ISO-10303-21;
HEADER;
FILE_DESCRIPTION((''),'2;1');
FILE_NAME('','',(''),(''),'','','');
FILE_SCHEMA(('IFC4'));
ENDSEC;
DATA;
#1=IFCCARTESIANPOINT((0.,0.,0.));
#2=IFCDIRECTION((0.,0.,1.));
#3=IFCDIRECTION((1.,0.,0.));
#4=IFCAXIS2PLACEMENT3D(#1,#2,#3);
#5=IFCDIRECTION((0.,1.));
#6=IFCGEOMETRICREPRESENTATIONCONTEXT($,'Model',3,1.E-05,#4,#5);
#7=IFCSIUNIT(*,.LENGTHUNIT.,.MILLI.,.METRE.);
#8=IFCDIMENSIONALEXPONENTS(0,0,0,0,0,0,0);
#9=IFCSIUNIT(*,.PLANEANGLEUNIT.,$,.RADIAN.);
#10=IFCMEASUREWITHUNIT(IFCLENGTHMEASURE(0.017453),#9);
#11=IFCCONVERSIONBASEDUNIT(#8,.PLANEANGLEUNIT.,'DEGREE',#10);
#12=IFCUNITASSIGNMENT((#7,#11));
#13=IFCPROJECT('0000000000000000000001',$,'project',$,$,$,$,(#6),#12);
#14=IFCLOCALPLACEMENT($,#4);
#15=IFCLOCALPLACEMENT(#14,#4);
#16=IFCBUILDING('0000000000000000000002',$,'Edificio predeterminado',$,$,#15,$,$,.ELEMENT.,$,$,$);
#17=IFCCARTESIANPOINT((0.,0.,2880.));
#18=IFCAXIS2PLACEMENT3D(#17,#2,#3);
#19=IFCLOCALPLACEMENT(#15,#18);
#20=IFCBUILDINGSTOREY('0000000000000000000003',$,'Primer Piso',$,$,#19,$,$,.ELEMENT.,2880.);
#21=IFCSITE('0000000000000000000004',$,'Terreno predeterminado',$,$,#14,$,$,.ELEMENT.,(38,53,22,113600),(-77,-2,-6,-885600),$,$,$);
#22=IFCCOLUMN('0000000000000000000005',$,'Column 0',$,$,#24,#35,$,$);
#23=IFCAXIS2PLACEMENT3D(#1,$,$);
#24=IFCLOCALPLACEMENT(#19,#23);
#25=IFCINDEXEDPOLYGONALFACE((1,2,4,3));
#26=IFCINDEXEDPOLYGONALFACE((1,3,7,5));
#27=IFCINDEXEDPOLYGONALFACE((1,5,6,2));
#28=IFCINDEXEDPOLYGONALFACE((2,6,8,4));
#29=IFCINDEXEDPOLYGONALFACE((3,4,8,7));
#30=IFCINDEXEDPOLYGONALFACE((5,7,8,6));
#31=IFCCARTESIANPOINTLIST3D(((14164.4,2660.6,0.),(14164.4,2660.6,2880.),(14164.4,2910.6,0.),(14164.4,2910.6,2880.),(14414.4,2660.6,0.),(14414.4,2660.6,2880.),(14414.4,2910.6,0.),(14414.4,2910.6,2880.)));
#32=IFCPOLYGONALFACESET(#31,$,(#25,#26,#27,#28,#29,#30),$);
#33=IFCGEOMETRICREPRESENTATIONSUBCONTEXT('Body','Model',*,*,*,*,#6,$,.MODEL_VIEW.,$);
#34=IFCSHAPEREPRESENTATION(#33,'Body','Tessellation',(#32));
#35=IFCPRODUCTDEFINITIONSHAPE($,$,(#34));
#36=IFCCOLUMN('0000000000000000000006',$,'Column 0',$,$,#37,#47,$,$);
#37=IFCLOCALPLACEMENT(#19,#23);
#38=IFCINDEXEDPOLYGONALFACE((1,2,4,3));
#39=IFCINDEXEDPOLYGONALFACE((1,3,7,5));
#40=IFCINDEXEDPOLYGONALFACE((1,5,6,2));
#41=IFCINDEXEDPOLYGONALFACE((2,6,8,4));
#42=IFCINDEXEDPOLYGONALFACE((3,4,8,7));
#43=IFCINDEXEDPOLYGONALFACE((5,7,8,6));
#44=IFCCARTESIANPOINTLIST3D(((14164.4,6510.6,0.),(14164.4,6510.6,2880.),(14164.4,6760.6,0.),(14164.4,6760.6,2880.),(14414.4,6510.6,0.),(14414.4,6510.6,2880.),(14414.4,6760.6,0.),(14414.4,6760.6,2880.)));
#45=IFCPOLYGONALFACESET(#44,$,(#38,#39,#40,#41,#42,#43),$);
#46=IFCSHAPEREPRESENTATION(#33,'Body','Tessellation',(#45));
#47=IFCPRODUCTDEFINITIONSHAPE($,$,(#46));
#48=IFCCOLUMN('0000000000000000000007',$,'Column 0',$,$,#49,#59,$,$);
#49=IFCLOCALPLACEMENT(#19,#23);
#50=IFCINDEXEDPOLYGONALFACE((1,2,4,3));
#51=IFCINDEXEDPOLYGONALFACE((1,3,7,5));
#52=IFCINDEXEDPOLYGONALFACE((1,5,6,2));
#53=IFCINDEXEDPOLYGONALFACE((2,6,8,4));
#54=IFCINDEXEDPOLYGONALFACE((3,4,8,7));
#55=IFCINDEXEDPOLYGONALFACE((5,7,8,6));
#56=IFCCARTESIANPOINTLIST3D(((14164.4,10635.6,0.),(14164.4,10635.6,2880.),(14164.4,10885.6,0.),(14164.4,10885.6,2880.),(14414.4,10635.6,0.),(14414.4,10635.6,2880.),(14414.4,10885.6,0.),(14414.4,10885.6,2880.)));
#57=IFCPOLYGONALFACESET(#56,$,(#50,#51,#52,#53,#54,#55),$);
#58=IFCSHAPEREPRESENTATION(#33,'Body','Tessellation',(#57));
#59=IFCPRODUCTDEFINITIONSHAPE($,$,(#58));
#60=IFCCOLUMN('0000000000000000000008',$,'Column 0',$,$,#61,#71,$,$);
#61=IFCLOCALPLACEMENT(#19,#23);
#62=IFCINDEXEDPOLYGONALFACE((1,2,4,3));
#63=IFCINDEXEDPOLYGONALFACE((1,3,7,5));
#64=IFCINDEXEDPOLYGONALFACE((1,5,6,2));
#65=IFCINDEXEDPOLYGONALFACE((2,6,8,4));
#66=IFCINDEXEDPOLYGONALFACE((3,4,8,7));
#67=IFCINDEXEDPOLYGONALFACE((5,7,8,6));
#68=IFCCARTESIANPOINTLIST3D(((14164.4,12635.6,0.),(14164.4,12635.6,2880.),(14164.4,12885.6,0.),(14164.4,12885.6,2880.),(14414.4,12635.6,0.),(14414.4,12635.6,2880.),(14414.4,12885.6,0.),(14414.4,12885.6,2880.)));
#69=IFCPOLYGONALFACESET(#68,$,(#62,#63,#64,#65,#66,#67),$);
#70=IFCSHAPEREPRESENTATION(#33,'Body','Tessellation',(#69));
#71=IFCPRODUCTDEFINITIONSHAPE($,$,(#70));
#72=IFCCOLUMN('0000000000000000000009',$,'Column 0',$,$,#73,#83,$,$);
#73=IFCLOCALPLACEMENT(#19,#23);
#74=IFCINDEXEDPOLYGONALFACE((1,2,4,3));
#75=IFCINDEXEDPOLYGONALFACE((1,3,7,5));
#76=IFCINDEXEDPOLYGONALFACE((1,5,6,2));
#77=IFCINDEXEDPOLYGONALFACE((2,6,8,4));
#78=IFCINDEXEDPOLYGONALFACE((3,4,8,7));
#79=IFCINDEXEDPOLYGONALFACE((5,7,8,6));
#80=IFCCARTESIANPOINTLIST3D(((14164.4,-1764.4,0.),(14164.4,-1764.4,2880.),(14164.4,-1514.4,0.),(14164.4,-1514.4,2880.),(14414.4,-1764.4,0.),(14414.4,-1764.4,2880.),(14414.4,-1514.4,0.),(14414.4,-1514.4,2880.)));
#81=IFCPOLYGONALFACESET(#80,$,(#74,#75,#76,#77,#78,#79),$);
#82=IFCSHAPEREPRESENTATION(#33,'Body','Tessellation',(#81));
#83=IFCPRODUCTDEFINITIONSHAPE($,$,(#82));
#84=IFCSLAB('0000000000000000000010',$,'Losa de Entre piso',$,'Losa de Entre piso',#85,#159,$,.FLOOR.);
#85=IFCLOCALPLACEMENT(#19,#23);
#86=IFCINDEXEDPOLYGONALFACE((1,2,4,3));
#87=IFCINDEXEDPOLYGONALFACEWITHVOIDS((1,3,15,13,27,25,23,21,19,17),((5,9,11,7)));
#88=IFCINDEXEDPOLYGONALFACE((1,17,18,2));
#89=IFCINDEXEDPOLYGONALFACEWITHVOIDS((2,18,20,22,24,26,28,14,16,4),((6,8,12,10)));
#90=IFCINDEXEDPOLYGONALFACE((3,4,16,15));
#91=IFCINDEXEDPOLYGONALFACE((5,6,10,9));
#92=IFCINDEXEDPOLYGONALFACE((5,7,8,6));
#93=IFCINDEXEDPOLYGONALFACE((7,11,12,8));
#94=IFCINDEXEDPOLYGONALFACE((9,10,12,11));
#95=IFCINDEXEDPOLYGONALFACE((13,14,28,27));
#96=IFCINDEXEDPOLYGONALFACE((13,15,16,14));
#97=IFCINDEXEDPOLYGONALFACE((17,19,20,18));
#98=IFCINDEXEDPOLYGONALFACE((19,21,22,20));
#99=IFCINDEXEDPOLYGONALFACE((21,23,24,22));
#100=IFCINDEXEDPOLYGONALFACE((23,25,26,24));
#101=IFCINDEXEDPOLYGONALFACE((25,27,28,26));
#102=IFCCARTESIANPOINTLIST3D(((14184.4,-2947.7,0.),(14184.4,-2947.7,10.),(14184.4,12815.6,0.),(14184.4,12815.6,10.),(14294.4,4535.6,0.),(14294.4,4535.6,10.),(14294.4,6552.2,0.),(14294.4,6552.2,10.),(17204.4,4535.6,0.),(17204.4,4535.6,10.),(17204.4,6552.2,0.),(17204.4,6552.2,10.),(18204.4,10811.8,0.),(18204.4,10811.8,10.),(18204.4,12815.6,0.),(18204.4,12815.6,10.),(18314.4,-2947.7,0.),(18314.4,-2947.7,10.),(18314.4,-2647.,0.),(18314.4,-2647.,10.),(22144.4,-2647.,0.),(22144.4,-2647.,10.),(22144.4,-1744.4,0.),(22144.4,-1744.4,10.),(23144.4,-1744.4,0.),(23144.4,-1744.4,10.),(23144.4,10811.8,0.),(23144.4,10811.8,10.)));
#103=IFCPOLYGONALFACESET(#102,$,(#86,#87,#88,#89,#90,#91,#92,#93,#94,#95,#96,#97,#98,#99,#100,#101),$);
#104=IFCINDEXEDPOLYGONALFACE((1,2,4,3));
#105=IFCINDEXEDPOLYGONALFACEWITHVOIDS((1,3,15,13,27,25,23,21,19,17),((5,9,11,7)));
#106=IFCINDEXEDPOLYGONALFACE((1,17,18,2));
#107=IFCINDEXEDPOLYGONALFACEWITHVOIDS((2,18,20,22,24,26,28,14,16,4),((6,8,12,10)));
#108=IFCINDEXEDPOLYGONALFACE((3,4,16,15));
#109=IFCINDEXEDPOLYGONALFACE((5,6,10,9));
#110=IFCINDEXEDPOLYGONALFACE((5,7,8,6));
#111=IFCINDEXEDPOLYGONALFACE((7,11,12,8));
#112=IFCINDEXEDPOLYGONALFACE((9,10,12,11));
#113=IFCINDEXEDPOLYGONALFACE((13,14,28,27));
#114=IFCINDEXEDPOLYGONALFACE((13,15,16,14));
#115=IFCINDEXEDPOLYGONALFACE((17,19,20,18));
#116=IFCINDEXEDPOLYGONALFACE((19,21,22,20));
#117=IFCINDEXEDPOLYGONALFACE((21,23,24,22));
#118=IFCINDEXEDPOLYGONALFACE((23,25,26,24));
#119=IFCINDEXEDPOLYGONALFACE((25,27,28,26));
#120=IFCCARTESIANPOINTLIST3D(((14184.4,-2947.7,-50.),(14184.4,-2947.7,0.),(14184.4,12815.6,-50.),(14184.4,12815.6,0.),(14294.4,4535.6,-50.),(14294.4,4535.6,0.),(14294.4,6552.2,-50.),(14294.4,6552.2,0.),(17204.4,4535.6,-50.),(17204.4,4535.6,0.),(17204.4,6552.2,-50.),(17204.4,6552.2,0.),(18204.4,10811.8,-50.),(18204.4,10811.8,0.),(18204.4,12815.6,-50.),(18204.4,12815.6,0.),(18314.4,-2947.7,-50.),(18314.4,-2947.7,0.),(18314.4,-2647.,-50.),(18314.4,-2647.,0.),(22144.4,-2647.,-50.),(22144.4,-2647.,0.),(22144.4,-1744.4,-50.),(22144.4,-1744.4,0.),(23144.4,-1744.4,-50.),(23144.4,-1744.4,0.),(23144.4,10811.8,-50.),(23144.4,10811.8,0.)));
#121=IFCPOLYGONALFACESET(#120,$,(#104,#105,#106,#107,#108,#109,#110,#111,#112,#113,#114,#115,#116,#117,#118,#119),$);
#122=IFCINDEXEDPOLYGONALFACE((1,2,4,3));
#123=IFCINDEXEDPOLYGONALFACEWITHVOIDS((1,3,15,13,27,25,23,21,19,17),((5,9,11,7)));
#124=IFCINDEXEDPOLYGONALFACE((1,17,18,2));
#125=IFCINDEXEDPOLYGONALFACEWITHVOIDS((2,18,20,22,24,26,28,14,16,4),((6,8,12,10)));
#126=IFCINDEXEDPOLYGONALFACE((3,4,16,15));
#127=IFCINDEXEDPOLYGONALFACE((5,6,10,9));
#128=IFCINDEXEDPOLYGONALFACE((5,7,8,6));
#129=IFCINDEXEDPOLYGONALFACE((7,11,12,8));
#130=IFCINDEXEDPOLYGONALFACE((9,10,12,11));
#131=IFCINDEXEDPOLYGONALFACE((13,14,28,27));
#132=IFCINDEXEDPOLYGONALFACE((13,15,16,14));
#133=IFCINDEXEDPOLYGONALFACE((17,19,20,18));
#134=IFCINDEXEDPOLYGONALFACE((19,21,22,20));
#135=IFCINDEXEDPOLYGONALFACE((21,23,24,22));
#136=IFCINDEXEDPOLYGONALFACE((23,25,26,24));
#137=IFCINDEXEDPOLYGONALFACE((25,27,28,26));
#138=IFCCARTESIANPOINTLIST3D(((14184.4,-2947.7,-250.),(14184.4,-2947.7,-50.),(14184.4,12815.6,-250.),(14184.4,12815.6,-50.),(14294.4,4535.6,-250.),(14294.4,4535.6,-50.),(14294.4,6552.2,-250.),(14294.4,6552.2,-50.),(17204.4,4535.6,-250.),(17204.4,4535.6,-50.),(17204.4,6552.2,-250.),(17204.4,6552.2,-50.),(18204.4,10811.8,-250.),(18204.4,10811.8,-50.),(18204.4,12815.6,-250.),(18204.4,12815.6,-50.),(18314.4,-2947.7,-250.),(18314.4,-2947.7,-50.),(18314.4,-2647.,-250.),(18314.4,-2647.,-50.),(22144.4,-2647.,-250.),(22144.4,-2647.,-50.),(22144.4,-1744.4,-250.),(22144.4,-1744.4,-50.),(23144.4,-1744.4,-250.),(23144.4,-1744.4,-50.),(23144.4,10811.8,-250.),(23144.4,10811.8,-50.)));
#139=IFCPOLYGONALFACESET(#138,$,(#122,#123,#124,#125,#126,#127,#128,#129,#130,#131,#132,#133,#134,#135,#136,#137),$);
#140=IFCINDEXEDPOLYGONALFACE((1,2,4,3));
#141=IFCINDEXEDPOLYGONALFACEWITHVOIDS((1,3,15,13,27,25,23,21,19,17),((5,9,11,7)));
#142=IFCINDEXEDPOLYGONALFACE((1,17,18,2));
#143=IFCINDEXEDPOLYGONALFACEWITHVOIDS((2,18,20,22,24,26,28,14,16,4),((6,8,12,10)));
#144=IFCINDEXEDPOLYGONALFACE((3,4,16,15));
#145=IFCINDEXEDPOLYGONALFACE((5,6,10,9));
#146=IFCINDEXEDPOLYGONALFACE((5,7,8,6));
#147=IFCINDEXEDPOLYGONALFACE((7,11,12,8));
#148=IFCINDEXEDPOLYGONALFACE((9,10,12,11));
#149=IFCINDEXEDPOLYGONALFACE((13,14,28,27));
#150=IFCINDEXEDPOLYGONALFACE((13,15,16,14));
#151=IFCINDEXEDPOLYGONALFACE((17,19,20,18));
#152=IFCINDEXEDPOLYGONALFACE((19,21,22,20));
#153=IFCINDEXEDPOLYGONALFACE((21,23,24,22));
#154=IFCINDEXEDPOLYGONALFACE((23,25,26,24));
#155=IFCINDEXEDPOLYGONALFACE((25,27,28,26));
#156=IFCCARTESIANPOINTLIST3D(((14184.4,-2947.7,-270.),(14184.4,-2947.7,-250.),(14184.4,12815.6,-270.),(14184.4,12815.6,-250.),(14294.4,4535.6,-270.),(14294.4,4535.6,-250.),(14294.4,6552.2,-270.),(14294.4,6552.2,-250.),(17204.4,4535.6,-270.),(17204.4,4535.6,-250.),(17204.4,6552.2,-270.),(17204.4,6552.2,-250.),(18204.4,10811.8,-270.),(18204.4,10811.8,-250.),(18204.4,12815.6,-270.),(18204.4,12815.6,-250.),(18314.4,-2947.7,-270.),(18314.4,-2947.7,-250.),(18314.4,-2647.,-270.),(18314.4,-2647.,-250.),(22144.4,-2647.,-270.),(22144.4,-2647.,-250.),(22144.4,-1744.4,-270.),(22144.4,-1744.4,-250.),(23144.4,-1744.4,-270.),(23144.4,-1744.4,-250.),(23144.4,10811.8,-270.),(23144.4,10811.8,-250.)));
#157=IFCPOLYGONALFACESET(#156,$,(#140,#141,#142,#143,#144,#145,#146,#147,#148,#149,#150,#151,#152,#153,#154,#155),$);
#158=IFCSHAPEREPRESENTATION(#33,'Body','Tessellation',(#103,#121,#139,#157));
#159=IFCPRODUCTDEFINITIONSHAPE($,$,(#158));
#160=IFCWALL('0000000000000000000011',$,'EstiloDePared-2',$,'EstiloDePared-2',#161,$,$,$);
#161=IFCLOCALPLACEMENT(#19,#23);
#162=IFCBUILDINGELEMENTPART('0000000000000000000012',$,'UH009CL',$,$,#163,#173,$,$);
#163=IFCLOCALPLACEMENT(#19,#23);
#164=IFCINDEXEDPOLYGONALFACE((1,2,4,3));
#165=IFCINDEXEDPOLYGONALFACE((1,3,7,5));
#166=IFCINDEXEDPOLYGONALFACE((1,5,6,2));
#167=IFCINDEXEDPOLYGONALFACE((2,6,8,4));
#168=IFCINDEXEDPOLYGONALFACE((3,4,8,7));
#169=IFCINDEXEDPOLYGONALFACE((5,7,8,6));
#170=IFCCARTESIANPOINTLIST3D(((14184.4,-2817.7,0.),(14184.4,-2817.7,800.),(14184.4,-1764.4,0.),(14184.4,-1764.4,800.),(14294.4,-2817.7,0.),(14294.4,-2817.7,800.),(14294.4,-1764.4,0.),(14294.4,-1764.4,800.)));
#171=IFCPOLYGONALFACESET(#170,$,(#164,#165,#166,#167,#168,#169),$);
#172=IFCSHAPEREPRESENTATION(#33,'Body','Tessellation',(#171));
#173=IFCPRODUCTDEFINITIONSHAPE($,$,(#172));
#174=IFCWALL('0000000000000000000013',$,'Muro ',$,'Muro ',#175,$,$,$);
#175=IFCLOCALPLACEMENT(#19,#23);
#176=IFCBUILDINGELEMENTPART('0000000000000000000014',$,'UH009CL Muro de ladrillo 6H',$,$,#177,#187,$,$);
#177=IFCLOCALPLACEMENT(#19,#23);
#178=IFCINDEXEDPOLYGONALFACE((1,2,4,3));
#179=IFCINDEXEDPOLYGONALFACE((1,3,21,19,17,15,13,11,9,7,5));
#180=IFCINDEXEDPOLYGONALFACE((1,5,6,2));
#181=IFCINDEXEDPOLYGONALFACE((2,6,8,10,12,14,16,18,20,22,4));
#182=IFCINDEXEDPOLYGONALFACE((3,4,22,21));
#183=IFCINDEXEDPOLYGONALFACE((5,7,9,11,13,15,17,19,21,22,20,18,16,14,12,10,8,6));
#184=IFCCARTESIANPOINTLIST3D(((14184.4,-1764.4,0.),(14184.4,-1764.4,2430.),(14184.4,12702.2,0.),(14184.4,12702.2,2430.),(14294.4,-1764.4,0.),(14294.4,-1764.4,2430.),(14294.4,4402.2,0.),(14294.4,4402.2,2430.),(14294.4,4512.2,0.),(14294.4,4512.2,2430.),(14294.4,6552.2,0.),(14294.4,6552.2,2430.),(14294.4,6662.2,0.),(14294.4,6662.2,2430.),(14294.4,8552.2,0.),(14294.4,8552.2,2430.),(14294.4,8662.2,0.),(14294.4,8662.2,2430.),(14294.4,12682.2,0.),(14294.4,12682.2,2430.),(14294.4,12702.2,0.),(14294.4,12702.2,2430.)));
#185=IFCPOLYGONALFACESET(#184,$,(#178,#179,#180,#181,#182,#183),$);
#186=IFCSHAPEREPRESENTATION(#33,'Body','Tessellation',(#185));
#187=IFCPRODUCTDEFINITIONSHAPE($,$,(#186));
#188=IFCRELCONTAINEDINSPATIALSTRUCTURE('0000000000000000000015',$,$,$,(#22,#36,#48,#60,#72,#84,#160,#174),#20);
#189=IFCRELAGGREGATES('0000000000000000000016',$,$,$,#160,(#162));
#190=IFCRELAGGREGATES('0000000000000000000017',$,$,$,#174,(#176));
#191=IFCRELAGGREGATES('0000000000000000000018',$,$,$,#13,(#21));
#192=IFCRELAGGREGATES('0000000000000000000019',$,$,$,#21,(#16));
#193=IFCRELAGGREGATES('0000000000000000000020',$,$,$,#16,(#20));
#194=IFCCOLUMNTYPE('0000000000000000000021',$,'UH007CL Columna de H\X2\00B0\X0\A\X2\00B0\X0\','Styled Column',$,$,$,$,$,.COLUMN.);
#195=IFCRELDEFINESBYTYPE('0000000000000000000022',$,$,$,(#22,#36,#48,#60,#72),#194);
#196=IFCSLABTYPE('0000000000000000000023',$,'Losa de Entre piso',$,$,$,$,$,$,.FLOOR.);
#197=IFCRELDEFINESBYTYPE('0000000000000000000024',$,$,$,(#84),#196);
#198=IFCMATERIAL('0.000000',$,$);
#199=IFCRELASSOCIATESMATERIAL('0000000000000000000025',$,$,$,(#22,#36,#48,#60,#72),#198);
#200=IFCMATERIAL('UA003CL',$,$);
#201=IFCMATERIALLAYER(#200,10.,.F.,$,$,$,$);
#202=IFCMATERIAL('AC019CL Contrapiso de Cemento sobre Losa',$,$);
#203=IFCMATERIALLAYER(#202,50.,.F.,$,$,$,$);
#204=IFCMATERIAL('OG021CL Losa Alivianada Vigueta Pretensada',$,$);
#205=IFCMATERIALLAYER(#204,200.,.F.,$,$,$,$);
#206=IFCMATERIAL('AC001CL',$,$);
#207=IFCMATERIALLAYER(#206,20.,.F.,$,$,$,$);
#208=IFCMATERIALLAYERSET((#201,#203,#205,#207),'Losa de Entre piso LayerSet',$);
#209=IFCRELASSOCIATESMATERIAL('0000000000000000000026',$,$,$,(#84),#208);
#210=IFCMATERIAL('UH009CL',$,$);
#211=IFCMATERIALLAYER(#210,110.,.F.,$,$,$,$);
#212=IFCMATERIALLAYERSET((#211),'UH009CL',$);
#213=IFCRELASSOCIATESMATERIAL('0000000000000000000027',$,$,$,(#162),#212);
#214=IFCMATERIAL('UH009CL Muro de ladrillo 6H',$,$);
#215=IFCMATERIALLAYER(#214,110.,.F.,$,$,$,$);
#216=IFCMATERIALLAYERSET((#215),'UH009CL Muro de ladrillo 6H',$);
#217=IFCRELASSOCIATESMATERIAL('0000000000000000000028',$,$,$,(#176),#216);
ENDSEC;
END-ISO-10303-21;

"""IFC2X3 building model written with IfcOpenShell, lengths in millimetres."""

from ifc_helpers import new_model, entity, si_unit, converted_unit, direction, frame, origin_with_axes, place, context, subcontext, project, spatial, polyline, outline, extrude, material, layer, layer_set, layer_usage, type_object, element, aggregate, save


model = new_model("IFC2X3")

# Units and contexts
model_context = context("Model", 3, precision=1e-05, world=origin_with_axes(), true_north=direction((0.0, 1.0)))
body_context = subcontext(model_context, "Body", "Model", "MODEL_VIEW")
ifc_project = project(units=[si_unit("LENGTHUNIT", "METRE", prefix="MILLI"), converted_unit("PLANEANGLEUNIT", "DEGREE", entity("IfcLengthMeasure", 0.017453), si_unit("PLANEANGLEUNIT", "RADIAN"), dimensions=[0, 0, 0, 0, 0, 0, 0])], contexts=[model_context])

# Site, building, storey
site_placement = place(None, origin_with_axes())
site = spatial("IfcSite", under=ifc_project, at=site_placement, Name="Terreno predeterminado", CompositionType="ELEMENT", RefLatitude=(38, 53, 22, 113600), RefLongitude=(-77, -2, -6, -885600))
building_placement = place(site_placement, origin_with_axes())
building = spatial("IfcBuilding", under=site, at=building_placement, Name="Edificio predeterminado", CompositionType="ELEMENT")
storey_placement = place(building_placement, frame((0.0, 0.0, 2880.0), z_axis=(0.0, 0.0, 1.0), x_axis=(1.0, 0.0, 0.0)))
storey = spatial("IfcBuildingStorey", under=building, at=storey_placement, Name="Primer Piso", CompositionType="ELEMENT", Elevation=2880.0)

# Columns
ifc_material_1 = material(Name="0.000000")
column_type = type_object("IfcColumnType", Name="UH007CL Columna de H°A°", Description="Styled Column", PredefinedType="COLUMN")
for number, where, z_axis, x_axis, name in (
    (1, (14289.4, 2785.6, 0.0), (0.0, 0.0, 1.0), (1.0, 0.0, 0.0), "Column 0"),
    (2, (14289.4, 6635.6, 0.0), (0.0, 0.0, 1.0), (1.0, 0.0, 0.0), "Column 0"),
    (3, (14289.4, 10760.6, 0.0), (0.0, 0.0, 1.0), (1.0, 0.0, 0.0), "Column 0"),
    (4, (14289.4, 12760.6, 0.0), (0.0, 0.0, 1.0), (1.0, 0.0, 0.0), "Column 0"),
    (5, (14289.4, -1639.4, 0.0), (0.0, 0.0, 1.0), (1.0, 0.0, 0.0), "Column 0"),
):
    element("IfcColumn", number, at=place(storey_placement, frame(where, z_axis=z_axis, x_axis=x_axis)), inside=storey, type_object=column_type, material=ifc_material_1, Name=name, context=body_context, shape_type="SweptSolid", body=[
        extrude(outline(polyline([(-125.0, -125.0), (125.0, -125.0), (125.0, 125.0), (-125.0, 125.0), (-125.0, -125.0)])), origin_with_axes(), (0.0, 0.0, 1.0), 2880.0),
    ])

# Slab
ifc_material_2 = material(Name="UA003CL")
ifc_layer_1 = layer(ifc_material_2, 10.0, ventilated=False)
ifc_material_3 = material(Name="AC019CL Contrapiso de Cemento sobre Losa")
ifc_layer_2 = layer(ifc_material_3, 50.0, ventilated=False)
ifc_material_4 = material(Name="OG021CL Losa Alivianada Vigueta Pretensada")
ifc_layer_3 = layer(ifc_material_4, 200.0, ventilated=False)
ifc_material_5 = material(Name="AC001CL")
ifc_layer_4 = layer(ifc_material_5, 20.0, ventilated=False)
ifc_layer_set_1 = layer_set([ifc_layer_1, ifc_layer_2, ifc_layer_3, ifc_layer_4], Name="Losa de Entre piso LayerSet")
ifc_layer_usage_1 = layer_usage(ifc_layer_set_1, "AXIS3", "NEGATIVE", 0.0)
slab_type = type_object("IfcSlabType", Name="Losa de Entre piso", PredefinedType="FLOOR")
slab_placement = place(storey_placement, frame((0.0, 0.0, -2880.0), z_axis=(0.0, 0.0, 1.0), x_axis=(1.0, 0.0, 0.0)))
element("IfcSlab", 6, at=slab_placement, inside=storey, type_object=slab_type, material=ifc_layer_usage_1, Name="Losa de Entre piso", ObjectType="Losa de Entre piso", PredefinedType="FLOOR", context=body_context, shape_type="SweptSolid", body=[
    extrude(outline(polyline([(0.0, 15763.4), (4130.0, 15763.4), (4130.0, 15462.6), (7960.0, 15462.6), (7960.0, 14560.0), (8960.0, 14560.0), (8960.0, 2003.8), (4020.0, 2003.8), (4020.0, 0.0), (0.0, 0.0), (0.0, 15763.4)]), holes=[polyline([(110.0, 6263.4), (3020.0, 6263.4), (3020.0, 8280.0), (110.0, 8280.0), (110.0, 6263.4)])]), frame((14184.4, 12815.6, 2880.0), z_axis=(0.0, 0.0, -1.0), x_axis=(1.0, 0.0, 0.0)), (0.0, 0.0, -1.0), 10.0),
    extrude(outline(polyline([(0.0, 15763.4), (4130.0, 15763.4), (4130.0, 15462.6), (7960.0, 15462.6), (7960.0, 14560.0), (8960.0, 14560.0), (8960.0, 2003.8), (4020.0, 2003.8), (4020.0, 0.0), (0.0, 0.0), (0.0, 15763.4)]), holes=[polyline([(110.0, 6263.4), (3020.0, 6263.4), (3020.0, 8280.0), (110.0, 8280.0), (110.0, 6263.4)])]), frame((14184.4, 12815.6, 2830.0), z_axis=(0.0, 0.0, -1.0), x_axis=(1.0, 0.0, 0.0)), (0.0, 0.0, -1.0), 50.0),
    extrude(outline(polyline([(0.0, 15763.4), (4130.0, 15763.4), (4130.0, 15462.6), (7960.0, 15462.6), (7960.0, 14560.0), (8960.0, 14560.0), (8960.0, 2003.8), (4020.0, 2003.8), (4020.0, 0.0), (0.0, 0.0), (0.0, 15763.4)]), holes=[polyline([(110.0, 6263.4), (3020.0, 6263.4), (3020.0, 8280.0), (110.0, 8280.0), (110.0, 6263.4)])]), frame((14184.4, 12815.6, 2630.0), z_axis=(0.0, 0.0, -1.0), x_axis=(1.0, 0.0, 0.0)), (0.0, 0.0, -1.0), 200.0),
    extrude(outline(polyline([(0.0, 15763.4), (4130.0, 15763.4), (4130.0, 15462.6), (7960.0, 15462.6), (7960.0, 14560.0), (8960.0, 14560.0), (8960.0, 2003.8), (4020.0, 2003.8), (4020.0, 0.0), (0.0, 0.0), (0.0, 15763.4)]), holes=[polyline([(110.0, 6263.4), (3020.0, 6263.4), (3020.0, 8280.0), (110.0, 8280.0), (110.0, 6263.4)])]), frame((14184.4, 12815.6, 2610.0), z_axis=(0.0, 0.0, -1.0), x_axis=(1.0, 0.0, 0.0)), (0.0, 0.0, -1.0), 20.0),
])

# Walls, building element parts
wall_1_placement = place(storey_placement, frame((14239.4, -2817.7, 0.0), z_axis=(0.0, 0.0, 1.0), x_axis=(0.0, 1.0, 0.0)))
wall_1 = element("IfcWall", 7, at=wall_1_placement, inside=storey, Name="EstiloDePared-2", ObjectType="EstiloDePared-2")
ifc_material_6 = material(Name="UH009CL")
ifc_layer_5 = layer(ifc_material_6, 110.0, ventilated=False)
ifc_layer_set_2 = layer_set([ifc_layer_5], Name="UH009CL")
ifc_layer_usage_2 = layer_usage(ifc_layer_set_2, "AXIS2", "NEGATIVE", -55.0)
building_element_part_1_placement = place(wall_1_placement, origin_with_axes())
building_element_part_1 = element("IfcBuildingElementPart", 8, at=building_element_part_1_placement, material=ifc_layer_usage_2, Name="UH009CL", context=body_context, shape_type="SweptSolid", body=[
    extrude(outline(polyline([(1053.4, 55.0), (1053.4, -55.0), (0.0, -55.0), (0.0, 55.0), (1053.4, 55.0)])), origin_with_axes(), (0.0, 0.0, 1.0), 800.0),
])
aggregate(wall_1, [building_element_part_1])
wall_2_placement = place(storey_placement, frame((14239.4, -1764.4, 0.0), z_axis=(0.0, 0.0, 1.0), x_axis=(0.0, 1.0, 0.0)))
wall_2 = element("IfcWall", 9, at=wall_2_placement, inside=storey, Name="Muro ", ObjectType="Muro ")
ifc_material_7 = material(Name="UH009CL Muro de ladrillo 6H")
ifc_layer_6 = layer(ifc_material_7, 110.0, ventilated=False)
ifc_layer_set_3 = layer_set([ifc_layer_6], Name="UH009CL Muro de ladrillo 6H")
ifc_layer_usage_3 = layer_usage(ifc_layer_set_3, "AXIS2", "NEGATIVE", -55.0)
building_element_part_2_placement = place(wall_2_placement, origin_with_axes())
building_element_part_2 = element("IfcBuildingElementPart", 10, at=building_element_part_2_placement, material=ifc_layer_usage_3, Name="UH009CL Muro de ladrillo 6H", context=body_context, shape_type="SweptSolid", body=[
    extrude(outline(polyline([(14466.6, 55.0), (14466.6, -55.0), (14446.6, -55.0), (10426.6, -55.0), (10316.6, -55.0), (8426.6, -55.0), (8316.6, -55.0), (6276.6, -55.0), (6166.6, -55.0), (0.0, -55.0), (0.0, 55.0), (14466.6, 55.0)])), origin_with_axes(), (0.0, 0.0, 1.0), 2430.0),
])
aggregate(wall_2, [building_element_part_2])

save(model, "model.ifc")
